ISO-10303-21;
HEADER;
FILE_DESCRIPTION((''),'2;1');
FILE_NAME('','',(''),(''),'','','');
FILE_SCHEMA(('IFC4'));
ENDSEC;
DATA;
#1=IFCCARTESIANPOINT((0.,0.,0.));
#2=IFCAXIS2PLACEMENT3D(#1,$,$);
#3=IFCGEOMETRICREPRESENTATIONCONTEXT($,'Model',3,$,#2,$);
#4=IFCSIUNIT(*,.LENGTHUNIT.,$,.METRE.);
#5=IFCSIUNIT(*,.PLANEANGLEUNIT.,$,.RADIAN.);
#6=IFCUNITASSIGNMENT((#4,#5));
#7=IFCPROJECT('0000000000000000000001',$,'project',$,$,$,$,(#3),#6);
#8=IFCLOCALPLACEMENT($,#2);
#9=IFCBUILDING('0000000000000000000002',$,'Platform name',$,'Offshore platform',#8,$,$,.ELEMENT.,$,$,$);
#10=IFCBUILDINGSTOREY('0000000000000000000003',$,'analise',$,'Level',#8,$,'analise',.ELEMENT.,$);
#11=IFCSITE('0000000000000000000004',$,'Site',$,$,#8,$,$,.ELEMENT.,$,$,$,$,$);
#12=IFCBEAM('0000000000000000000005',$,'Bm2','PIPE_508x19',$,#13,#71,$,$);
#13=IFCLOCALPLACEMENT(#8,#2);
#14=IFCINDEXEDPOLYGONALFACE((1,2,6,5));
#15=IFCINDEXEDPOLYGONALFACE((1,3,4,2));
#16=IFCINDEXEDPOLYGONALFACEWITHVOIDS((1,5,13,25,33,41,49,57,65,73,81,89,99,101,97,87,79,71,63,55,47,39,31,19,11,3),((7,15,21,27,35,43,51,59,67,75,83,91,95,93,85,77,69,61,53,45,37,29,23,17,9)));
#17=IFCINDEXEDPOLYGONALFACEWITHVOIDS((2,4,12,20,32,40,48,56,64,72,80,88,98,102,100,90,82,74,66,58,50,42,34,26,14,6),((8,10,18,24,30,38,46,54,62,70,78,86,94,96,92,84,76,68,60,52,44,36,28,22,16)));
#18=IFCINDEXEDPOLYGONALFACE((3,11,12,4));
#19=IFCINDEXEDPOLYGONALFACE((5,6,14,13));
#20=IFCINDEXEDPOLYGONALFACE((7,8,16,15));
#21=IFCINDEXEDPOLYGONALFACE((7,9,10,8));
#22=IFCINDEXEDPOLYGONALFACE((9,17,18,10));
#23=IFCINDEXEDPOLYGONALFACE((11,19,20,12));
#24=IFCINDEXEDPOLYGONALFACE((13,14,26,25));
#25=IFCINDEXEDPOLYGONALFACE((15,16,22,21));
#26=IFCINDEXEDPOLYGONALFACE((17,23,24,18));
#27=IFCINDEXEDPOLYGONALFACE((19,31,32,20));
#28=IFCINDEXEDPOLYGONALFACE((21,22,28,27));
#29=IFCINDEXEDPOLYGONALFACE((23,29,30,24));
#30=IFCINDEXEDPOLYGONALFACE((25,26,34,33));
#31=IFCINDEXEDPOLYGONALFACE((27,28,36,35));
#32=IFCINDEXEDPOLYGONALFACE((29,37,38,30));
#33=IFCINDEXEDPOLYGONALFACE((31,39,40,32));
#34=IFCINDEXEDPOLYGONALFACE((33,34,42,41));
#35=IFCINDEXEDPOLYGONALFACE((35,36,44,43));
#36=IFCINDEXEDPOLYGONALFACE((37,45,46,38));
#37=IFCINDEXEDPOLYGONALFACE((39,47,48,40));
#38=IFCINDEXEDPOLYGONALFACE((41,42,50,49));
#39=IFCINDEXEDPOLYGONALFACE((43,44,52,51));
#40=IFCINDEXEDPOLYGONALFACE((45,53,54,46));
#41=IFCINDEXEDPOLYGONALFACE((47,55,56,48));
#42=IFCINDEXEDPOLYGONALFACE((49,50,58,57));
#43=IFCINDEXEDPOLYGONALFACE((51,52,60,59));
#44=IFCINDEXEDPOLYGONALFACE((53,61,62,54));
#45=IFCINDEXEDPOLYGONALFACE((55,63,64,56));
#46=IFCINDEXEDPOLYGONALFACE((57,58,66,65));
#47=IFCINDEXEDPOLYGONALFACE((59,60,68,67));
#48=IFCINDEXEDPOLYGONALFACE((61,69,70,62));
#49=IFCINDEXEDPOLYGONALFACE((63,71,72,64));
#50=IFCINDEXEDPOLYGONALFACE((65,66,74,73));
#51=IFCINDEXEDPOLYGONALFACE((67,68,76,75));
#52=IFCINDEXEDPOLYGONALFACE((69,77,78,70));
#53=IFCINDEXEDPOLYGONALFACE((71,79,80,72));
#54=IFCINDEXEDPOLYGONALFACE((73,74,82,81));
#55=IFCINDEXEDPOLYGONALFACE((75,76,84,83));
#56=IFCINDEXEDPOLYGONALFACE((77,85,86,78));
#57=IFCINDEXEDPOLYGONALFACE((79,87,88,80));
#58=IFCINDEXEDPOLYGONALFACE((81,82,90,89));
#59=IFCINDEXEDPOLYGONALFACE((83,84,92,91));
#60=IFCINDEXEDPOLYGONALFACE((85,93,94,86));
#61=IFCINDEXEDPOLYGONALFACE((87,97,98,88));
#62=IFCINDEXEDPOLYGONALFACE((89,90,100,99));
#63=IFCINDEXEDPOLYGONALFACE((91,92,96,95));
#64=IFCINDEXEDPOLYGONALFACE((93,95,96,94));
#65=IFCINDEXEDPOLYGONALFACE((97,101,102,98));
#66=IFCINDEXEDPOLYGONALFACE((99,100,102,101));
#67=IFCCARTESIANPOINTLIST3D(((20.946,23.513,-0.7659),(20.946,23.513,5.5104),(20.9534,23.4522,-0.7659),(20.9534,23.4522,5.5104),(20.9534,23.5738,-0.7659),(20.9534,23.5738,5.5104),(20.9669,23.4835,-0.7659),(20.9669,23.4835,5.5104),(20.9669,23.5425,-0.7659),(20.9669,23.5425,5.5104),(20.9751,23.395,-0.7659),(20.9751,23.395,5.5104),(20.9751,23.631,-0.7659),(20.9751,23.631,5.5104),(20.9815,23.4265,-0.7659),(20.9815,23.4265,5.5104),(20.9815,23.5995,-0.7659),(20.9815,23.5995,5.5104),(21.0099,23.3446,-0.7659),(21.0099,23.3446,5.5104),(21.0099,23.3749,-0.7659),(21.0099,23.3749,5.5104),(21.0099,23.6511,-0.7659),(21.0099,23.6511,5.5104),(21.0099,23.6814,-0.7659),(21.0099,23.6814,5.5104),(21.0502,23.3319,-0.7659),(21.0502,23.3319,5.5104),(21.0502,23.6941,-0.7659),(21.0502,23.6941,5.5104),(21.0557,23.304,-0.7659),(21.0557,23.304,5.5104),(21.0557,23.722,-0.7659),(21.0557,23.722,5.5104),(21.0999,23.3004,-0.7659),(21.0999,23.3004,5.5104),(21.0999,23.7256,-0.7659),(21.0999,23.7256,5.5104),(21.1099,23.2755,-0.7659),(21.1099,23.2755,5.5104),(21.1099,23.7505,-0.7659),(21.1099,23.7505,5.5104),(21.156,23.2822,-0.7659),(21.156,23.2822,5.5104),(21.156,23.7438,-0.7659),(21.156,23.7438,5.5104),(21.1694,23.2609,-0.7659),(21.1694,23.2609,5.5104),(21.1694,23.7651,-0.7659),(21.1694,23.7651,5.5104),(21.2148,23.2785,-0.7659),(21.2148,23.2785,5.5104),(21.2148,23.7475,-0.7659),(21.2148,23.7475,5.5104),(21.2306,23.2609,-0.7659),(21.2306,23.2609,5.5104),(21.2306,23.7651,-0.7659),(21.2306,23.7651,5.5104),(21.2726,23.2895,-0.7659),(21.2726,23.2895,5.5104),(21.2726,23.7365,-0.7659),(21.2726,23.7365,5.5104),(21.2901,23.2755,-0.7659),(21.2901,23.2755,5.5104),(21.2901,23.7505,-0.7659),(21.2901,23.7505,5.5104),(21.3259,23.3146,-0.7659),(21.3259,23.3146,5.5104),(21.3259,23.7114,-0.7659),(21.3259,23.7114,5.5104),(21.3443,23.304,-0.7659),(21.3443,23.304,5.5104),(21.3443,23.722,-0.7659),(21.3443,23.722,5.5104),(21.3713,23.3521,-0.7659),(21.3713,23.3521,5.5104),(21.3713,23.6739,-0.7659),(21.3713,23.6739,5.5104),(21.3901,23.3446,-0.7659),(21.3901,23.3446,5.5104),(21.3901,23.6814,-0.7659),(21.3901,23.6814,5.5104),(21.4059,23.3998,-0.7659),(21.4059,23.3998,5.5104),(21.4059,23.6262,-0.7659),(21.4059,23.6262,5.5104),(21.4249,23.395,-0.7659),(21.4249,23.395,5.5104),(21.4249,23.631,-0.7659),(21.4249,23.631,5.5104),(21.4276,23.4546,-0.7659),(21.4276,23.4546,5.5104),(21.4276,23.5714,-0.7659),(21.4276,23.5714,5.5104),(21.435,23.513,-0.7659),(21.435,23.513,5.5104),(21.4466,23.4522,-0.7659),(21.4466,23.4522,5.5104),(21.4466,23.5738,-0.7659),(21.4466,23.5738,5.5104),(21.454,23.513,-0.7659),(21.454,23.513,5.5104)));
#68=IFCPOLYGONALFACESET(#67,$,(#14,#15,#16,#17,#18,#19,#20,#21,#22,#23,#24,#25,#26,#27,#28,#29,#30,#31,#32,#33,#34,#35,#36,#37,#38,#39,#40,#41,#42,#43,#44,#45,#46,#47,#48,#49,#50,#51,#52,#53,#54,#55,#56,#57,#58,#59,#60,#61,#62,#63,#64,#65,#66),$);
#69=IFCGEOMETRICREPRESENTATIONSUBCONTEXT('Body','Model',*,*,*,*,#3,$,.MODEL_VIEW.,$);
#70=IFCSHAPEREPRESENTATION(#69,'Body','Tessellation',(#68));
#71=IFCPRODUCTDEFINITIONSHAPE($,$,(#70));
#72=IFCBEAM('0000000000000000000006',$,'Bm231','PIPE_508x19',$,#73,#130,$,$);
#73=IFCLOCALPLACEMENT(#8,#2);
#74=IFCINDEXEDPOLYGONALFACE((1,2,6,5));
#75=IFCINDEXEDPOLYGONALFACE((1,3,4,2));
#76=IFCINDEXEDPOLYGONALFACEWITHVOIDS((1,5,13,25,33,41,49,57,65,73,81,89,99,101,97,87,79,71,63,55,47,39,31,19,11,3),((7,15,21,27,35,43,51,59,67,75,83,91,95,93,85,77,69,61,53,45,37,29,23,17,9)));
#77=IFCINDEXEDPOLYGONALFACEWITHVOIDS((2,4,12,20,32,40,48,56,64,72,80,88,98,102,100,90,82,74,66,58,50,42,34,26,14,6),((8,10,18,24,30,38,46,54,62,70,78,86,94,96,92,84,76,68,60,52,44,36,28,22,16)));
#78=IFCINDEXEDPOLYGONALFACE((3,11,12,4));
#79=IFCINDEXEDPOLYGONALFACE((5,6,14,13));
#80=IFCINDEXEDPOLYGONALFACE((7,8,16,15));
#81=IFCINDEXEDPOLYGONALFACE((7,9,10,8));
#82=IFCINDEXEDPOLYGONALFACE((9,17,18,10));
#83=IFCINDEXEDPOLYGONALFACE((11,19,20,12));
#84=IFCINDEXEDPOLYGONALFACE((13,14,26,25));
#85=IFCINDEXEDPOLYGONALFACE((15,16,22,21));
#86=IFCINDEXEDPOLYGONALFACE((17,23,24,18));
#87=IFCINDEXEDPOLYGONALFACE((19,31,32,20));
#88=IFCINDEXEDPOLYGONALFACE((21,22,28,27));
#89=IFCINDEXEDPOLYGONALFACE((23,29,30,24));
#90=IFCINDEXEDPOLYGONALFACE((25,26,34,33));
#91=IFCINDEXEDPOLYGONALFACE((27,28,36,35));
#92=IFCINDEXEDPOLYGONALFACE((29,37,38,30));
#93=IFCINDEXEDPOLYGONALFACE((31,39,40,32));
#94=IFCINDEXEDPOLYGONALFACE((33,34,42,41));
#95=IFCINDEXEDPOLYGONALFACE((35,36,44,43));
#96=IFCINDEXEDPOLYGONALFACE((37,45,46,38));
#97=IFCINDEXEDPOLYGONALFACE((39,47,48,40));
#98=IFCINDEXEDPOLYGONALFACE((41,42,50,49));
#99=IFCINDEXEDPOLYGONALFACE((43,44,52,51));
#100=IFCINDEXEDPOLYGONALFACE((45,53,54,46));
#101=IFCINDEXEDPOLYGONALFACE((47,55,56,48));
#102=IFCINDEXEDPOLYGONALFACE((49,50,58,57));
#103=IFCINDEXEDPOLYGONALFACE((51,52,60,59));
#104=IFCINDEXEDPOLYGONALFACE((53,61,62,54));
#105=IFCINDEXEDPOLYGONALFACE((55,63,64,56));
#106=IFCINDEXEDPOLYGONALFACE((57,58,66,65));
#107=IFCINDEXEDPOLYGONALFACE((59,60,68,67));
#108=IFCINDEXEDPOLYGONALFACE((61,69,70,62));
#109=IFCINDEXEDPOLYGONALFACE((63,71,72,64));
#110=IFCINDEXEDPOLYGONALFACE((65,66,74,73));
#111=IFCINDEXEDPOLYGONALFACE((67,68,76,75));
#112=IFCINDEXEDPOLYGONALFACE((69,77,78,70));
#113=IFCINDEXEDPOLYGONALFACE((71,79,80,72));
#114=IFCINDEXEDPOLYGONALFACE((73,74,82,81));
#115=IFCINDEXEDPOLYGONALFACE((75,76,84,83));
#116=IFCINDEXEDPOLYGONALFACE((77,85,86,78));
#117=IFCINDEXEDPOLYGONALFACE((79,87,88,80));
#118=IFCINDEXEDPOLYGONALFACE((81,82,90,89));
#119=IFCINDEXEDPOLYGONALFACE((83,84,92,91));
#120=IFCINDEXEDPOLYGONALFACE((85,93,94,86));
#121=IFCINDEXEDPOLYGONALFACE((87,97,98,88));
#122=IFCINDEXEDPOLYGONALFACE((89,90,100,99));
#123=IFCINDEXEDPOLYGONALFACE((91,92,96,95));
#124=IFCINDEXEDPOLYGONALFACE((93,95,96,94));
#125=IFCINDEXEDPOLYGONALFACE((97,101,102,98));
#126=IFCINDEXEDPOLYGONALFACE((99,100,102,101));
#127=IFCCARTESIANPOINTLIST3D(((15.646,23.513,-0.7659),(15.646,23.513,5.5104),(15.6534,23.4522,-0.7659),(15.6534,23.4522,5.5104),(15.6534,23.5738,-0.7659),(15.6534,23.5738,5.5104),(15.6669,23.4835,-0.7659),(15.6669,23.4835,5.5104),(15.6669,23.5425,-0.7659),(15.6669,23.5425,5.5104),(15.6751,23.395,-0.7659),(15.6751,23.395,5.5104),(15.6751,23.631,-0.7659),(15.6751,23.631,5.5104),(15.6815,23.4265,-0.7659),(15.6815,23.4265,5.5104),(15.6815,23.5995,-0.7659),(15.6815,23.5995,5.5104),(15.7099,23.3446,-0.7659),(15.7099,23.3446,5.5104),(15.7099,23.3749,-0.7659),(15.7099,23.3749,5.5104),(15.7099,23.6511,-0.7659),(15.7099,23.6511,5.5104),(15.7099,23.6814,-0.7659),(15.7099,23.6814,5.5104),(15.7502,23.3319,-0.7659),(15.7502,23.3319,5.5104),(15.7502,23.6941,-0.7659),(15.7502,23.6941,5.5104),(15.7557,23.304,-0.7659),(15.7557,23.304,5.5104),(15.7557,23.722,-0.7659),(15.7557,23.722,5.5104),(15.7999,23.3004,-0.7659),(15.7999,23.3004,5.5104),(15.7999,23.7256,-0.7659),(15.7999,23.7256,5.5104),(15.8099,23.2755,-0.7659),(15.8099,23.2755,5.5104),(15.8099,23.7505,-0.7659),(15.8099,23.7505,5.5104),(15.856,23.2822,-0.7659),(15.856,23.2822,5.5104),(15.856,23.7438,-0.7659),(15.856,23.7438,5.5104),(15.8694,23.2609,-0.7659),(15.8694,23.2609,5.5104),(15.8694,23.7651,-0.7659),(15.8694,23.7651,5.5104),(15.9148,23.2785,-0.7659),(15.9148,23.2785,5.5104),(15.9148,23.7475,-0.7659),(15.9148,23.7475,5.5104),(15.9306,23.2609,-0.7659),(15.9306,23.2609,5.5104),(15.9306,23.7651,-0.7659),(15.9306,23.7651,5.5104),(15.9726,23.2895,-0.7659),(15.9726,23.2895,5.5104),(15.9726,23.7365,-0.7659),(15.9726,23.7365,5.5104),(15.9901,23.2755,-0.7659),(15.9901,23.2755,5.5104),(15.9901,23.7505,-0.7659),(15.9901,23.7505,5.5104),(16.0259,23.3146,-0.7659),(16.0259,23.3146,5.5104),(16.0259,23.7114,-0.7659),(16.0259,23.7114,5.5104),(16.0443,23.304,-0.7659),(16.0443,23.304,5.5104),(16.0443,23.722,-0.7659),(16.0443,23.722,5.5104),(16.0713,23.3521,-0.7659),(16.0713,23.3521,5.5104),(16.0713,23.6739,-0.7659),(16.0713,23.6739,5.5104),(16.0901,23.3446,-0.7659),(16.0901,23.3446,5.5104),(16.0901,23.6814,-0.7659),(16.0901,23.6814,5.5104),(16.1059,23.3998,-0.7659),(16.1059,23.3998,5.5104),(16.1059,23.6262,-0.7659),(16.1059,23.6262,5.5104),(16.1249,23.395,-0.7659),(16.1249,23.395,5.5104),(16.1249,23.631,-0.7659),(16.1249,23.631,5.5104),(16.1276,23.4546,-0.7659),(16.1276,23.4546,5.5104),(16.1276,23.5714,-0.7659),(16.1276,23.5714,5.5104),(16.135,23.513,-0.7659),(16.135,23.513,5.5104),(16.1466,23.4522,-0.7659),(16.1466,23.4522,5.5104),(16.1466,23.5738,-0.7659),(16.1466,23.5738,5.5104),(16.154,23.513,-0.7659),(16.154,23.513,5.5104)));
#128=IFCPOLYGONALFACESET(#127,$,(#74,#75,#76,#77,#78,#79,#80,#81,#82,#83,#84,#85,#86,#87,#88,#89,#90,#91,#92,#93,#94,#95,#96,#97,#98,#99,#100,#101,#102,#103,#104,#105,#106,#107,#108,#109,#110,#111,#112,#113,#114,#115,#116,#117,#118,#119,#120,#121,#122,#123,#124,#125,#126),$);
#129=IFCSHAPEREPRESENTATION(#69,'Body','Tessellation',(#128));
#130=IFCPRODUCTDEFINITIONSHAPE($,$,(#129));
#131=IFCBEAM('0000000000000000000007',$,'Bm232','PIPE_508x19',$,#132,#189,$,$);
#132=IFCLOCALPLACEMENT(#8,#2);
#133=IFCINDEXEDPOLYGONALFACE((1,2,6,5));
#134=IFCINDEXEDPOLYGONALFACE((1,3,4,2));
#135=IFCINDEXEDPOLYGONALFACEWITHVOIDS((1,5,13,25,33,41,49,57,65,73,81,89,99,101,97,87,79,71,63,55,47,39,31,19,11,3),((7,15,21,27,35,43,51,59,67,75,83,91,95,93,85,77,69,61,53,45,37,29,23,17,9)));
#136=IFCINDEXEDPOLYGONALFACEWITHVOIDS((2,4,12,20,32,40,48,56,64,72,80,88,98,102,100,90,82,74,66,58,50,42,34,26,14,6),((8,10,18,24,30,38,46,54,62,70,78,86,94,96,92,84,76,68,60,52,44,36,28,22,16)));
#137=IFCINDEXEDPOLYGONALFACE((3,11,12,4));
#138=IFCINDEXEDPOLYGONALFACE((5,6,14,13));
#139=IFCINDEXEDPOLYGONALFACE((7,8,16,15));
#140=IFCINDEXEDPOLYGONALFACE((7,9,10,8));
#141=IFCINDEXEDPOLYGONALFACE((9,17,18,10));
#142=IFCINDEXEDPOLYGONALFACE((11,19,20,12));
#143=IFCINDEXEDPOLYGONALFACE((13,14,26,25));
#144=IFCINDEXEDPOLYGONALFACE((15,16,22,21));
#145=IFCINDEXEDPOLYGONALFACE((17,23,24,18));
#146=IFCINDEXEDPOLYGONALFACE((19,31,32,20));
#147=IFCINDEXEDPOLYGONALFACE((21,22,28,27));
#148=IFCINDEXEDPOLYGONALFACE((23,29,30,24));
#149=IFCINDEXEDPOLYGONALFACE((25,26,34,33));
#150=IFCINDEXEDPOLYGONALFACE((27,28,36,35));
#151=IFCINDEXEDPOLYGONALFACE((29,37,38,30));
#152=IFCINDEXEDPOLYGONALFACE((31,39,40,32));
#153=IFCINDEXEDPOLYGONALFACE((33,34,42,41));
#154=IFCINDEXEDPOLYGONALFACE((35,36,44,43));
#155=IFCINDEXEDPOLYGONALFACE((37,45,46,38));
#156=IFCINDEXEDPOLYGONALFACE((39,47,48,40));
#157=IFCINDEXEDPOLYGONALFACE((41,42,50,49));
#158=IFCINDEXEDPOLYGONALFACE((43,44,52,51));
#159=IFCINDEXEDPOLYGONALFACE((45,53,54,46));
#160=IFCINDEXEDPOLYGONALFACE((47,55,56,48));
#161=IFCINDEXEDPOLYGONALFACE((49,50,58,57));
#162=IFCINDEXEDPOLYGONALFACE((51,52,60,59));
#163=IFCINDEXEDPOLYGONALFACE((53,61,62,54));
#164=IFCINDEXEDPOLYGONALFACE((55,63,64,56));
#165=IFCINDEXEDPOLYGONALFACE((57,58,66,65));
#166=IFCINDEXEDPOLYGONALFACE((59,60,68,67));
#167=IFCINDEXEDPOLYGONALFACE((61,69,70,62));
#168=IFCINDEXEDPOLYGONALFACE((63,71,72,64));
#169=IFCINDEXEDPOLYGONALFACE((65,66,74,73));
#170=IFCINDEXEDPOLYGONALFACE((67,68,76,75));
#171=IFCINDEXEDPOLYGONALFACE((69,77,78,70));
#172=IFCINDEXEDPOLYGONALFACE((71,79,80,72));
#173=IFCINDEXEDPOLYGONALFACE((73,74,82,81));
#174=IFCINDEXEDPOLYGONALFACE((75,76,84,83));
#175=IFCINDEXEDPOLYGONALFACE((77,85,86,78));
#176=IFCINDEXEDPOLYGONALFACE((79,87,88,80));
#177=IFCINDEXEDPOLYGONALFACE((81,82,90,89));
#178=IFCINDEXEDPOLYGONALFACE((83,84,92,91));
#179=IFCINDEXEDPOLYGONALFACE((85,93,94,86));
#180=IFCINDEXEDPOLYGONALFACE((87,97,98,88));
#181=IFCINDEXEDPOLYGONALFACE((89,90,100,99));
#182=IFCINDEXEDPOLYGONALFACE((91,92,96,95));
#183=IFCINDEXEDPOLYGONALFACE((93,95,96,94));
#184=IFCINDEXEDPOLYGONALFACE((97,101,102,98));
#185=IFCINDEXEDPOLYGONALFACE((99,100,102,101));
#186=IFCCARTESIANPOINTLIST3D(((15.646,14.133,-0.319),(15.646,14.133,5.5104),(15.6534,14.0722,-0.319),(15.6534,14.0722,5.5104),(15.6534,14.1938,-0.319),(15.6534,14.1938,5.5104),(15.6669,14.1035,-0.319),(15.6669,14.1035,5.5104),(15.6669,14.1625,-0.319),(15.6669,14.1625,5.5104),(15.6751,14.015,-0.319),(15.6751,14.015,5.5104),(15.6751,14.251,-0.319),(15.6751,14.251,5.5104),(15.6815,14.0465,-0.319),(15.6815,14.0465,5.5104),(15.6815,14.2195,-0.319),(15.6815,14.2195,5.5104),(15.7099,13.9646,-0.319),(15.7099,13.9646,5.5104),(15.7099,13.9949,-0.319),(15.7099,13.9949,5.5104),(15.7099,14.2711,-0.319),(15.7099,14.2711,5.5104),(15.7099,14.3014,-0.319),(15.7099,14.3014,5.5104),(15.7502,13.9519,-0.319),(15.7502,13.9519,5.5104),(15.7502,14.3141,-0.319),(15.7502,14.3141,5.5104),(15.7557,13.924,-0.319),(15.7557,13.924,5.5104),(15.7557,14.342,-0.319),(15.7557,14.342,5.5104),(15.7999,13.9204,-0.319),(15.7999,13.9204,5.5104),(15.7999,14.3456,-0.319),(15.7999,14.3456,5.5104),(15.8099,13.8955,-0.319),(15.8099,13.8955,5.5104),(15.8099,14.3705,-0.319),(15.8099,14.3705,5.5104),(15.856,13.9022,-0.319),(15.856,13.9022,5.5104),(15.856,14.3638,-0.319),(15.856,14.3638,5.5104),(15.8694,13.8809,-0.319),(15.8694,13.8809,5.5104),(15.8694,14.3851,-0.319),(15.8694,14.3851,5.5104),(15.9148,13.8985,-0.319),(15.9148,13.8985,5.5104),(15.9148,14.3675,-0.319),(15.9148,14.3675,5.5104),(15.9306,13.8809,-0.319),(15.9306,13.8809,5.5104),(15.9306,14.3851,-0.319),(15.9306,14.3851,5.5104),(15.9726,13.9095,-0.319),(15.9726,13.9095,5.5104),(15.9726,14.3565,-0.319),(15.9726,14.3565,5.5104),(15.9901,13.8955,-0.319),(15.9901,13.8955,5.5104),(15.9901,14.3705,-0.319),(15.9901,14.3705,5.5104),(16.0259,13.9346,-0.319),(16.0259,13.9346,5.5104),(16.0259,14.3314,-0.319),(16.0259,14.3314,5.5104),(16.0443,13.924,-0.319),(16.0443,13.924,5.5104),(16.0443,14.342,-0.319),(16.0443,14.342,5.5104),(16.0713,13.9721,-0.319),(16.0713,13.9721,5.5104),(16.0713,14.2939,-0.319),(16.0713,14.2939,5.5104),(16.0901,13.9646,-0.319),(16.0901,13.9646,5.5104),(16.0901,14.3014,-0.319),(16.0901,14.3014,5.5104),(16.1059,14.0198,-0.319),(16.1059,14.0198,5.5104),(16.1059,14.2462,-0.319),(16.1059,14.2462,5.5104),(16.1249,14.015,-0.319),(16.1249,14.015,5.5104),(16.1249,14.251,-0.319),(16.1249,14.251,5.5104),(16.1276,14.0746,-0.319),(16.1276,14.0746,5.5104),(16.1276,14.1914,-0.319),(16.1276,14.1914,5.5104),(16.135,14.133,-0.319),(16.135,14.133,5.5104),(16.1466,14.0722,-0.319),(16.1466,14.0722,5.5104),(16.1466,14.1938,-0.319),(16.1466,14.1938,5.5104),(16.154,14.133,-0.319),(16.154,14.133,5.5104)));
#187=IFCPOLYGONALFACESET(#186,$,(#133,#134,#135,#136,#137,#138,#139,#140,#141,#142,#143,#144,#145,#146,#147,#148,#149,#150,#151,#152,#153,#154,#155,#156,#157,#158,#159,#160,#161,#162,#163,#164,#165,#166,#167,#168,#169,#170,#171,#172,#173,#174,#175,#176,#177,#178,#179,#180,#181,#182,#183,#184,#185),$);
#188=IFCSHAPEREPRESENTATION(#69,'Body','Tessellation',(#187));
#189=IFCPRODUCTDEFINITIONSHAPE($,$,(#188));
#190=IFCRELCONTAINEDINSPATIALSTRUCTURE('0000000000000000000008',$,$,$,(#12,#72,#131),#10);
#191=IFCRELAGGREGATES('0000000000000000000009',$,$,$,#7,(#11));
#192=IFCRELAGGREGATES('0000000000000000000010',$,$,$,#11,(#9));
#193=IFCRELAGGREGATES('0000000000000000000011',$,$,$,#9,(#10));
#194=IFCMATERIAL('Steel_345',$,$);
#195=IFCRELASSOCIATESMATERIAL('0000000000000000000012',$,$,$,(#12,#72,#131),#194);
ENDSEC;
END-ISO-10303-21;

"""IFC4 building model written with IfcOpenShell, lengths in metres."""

from ifc_helpers import new_model, si_unit, frame, origin, origin_with_axes, origin_2d, place, context, subcontext, project, spatial, hollow_circle, extrude, source, transform, mapped, material, element, save


model = new_model("IFC4")

# Units and contexts
model_context = context("Model", 3, world=origin())
body_context = subcontext(model_context, "Body", "Model", "MODEL_VIEW")
ifc_project = project(units=[si_unit("LENGTHUNIT", "METRE"), si_unit("PLANEANGLEUNIT", "RADIAN")], contexts=[model_context])

# Site, building, storey
placement_1 = place(None, origin())
site = spatial("IfcSite", under=ifc_project, at=placement_1, Name="Site", CompositionType="ELEMENT")
building = spatial("IfcBuilding", under=site, at=placement_1, Name="Platform name", ObjectType="Offshore platform", CompositionType="ELEMENT")
storey = spatial("IfcBuildingStorey", under=building, at=placement_1, Name="analise", ObjectType="Level", LongName="analise", CompositionType="ELEMENT")

# Beams
ifc_material_1 = material(Name="Steel_345")
shared_shape_1 = source(origin(), body_context, "Body", "SweptSolid", [
    extrude(hollow_circle(Radius=0.254, WallThickness=0.019, at=origin_2d()), origin_with_axes(), (0.0, 0.0, 1.0), 6.2763),
])
placement_2 = place(None, origin())
placement_3 = place(placement_2, origin())
placement_4 = place(placement_3, origin())
beam_1_placement = place(placement_4, frame((21.2, 23.513, -0.7659)))
element("IfcBeam", 1, at=beam_1_placement, inside=storey, material=ifc_material_1, Name="Bm2", Description="PIPE_508x19", context=body_context, shape_type="MappedRepresentation", body=[
    mapped(shared_shape_1, transform((0.0, 0.0, 0.0), scale=1.0)),
])
shared_shape_2 = source(origin(), body_context, "Body", "SweptSolid", [
    extrude(hollow_circle(Radius=0.254, WallThickness=0.019, at=origin_2d()), origin_with_axes(), (0.0, 0.0, 1.0), 6.2763),
])
placement_5 = place(None, origin())
placement_6 = place(placement_5, origin())
placement_7 = place(placement_6, origin())
beam_2_placement = place(placement_7, frame((15.9, 23.513, -0.7659)))
element("IfcBeam", 2, at=beam_2_placement, inside=storey, material=ifc_material_1, Name="Bm231", Description="PIPE_508x19", context=body_context, shape_type="MappedRepresentation", body=[
    mapped(shared_shape_2, transform((0.0, 0.0, 0.0), scale=1.0)),
])
shared_shape_3 = source(origin(), body_context, "Body", "SweptSolid", [
    extrude(hollow_circle(Radius=0.254, WallThickness=0.019, at=origin_2d()), origin_with_axes(), (0.0, 0.0, 1.0), 5.8293),
])
placement_8 = place(None, origin())
placement_9 = place(placement_8, origin())
placement_10 = place(placement_9, origin())
beam_3_placement = place(placement_10, frame((15.9, 14.133, -0.319)))
element("IfcBeam", 3, at=beam_3_placement, inside=storey, material=ifc_material_1, Name="Bm232", Description="PIPE_508x19", context=body_context, shape_type="MappedRepresentation", body=[
    mapped(shared_shape_3, transform((0.0, 0.0, 0.0), scale=1.0)),
])

save(model, "model.ifc")
